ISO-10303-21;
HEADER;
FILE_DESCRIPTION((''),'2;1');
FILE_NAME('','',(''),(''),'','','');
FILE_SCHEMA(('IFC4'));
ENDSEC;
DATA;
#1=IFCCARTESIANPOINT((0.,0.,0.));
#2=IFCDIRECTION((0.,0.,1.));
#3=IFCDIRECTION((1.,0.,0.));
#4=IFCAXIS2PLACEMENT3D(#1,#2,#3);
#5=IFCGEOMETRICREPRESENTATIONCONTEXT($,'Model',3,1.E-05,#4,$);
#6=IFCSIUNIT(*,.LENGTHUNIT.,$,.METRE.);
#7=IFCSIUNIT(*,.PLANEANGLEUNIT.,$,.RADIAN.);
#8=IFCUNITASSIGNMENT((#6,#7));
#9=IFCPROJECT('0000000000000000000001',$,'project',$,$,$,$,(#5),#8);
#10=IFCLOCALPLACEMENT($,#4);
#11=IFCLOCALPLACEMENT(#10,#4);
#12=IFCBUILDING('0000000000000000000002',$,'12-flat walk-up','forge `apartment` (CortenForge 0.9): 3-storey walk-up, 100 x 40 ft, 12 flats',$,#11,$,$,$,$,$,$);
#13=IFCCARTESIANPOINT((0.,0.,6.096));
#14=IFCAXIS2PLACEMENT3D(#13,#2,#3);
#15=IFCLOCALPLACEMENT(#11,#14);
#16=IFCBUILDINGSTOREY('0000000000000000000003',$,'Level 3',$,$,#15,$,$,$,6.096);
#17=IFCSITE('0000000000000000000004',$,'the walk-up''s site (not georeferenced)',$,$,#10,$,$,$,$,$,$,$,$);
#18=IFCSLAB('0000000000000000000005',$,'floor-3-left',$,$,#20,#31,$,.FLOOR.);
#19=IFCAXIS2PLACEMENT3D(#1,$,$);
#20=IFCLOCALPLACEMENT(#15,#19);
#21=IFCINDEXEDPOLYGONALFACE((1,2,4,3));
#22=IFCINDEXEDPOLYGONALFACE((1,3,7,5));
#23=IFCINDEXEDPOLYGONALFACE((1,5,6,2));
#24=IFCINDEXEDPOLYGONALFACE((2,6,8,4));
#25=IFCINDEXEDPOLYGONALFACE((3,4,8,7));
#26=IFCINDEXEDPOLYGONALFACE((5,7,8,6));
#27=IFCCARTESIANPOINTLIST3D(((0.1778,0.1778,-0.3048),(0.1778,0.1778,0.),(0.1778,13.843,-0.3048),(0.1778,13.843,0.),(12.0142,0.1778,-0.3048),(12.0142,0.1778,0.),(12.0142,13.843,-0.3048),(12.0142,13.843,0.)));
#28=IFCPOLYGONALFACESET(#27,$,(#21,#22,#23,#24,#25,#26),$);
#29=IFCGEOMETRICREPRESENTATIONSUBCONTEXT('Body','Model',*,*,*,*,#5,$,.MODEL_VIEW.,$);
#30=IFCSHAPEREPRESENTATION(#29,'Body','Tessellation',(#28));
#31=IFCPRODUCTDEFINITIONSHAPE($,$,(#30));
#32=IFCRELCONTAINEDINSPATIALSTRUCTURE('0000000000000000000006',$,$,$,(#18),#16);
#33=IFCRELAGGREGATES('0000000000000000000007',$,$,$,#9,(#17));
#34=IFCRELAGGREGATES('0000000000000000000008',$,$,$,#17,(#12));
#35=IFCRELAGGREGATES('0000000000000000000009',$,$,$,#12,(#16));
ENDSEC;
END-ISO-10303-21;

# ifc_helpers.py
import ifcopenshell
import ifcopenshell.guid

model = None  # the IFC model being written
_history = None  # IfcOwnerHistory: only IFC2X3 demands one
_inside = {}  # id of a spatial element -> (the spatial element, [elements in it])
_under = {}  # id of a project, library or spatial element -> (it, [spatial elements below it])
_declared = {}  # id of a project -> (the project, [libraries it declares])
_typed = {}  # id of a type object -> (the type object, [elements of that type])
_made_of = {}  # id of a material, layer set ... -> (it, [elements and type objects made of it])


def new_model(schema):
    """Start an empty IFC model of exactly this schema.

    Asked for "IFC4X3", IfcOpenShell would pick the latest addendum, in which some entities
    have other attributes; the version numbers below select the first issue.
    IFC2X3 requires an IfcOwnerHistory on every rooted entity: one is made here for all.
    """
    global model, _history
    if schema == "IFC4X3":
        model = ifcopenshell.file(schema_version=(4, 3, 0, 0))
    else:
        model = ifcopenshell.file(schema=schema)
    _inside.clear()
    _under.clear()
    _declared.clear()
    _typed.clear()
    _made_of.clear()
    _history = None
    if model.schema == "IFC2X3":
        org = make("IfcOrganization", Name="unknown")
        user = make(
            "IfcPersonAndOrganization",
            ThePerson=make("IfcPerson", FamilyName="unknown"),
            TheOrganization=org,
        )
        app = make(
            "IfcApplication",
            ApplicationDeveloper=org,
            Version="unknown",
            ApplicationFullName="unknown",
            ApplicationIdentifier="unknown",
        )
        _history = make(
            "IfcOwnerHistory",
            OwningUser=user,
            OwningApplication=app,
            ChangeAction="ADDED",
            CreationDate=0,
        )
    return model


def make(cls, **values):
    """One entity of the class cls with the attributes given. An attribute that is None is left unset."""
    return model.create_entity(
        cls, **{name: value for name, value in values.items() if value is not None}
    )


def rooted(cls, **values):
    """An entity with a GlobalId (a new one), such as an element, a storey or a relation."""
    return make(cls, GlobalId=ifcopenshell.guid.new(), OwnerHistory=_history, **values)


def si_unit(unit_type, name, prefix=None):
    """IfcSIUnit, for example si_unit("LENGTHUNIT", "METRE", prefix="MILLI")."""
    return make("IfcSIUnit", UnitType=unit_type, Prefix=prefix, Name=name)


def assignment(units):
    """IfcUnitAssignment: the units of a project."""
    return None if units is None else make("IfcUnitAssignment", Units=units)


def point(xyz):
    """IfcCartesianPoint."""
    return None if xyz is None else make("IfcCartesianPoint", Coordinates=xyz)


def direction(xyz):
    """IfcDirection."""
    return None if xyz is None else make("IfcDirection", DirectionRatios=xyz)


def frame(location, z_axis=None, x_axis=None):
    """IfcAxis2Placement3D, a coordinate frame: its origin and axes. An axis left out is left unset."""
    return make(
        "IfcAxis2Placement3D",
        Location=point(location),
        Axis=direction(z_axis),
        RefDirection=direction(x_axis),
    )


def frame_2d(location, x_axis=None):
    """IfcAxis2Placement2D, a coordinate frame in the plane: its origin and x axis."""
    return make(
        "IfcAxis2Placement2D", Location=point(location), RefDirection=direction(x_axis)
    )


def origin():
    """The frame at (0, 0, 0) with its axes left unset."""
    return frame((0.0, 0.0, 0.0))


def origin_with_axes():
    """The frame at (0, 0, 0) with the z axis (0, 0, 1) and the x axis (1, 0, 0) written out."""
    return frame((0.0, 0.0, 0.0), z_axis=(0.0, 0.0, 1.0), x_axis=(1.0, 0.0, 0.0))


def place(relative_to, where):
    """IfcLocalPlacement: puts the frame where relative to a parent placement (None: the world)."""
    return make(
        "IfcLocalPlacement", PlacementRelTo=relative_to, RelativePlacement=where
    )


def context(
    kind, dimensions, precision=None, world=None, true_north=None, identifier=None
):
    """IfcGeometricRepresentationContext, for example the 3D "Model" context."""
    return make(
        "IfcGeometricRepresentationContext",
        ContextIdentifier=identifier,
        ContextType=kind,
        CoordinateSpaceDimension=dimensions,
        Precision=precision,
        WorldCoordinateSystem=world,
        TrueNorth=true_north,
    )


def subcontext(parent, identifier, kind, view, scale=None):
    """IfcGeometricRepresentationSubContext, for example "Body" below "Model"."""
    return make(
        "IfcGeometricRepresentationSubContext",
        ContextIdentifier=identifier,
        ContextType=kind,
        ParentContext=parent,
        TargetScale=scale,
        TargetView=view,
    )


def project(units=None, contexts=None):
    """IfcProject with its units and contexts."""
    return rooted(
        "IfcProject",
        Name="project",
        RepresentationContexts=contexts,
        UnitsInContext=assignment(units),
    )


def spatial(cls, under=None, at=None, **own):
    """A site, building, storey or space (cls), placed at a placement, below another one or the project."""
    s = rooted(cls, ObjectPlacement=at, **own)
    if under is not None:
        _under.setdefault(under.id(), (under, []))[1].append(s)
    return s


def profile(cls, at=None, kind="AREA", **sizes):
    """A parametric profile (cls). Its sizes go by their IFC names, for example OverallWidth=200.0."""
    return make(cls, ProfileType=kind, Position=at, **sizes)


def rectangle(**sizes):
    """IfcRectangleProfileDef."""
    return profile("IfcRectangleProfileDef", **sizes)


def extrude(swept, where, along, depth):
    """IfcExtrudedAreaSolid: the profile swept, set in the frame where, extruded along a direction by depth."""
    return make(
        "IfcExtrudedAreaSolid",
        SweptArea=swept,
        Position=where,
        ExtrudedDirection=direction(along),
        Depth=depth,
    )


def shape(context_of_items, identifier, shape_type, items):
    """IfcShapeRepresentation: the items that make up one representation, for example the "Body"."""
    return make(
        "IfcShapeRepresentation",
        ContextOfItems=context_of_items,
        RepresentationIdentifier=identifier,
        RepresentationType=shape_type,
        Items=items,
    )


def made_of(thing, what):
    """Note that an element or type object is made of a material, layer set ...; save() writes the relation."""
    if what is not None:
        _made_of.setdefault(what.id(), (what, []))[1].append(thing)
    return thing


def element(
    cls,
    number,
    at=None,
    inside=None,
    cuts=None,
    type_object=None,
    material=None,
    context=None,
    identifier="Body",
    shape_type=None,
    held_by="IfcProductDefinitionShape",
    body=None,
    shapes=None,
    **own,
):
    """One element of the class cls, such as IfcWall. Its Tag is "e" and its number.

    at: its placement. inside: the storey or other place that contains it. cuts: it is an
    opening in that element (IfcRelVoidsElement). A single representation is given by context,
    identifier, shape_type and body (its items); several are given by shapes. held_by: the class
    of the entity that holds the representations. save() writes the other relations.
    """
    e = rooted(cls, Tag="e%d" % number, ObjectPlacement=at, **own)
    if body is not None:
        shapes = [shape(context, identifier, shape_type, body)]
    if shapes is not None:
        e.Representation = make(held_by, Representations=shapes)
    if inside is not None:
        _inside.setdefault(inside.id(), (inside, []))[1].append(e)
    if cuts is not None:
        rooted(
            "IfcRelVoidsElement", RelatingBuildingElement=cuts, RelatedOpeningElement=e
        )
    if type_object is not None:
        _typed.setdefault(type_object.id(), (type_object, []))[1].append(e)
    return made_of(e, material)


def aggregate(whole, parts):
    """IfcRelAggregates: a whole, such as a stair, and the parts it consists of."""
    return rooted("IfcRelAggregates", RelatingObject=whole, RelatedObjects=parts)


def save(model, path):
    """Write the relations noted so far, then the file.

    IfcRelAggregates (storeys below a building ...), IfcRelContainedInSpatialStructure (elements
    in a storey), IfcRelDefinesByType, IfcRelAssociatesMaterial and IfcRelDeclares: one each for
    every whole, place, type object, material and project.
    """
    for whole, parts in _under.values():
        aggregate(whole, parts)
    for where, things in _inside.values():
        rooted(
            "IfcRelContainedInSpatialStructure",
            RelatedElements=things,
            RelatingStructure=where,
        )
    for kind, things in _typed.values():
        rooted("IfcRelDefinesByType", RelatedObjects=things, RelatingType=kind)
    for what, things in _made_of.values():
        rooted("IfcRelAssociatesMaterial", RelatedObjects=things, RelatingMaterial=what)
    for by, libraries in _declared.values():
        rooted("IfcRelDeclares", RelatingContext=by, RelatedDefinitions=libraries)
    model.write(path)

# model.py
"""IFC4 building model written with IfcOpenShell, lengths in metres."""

from ifc_helpers import new_model, si_unit, frame, frame_2d, origin, origin_with_axes, place, context, subcontext, project, spatial, rectangle, extrude, element, save


model = new_model("IFC4")

# Units and contexts
model_context = context("Model", 3, precision=1e-05, world=origin_with_axes())
body_context = subcontext(model_context, "Body", "Model", "MODEL_VIEW")
ifc_project = project(units=[si_unit("LENGTHUNIT", "METRE"), si_unit("PLANEANGLEUNIT", "RADIAN")], contexts=[model_context])

# Site, building, storey
site_placement = place(None, origin_with_axes())
site = spatial("IfcSite", under=ifc_project, at=site_placement, Name="the walk-up's site (not georeferenced)")
building_placement = place(site_placement, origin_with_axes())
building = spatial("IfcBuilding", under=site, at=building_placement, Name="12-flat walk-up", Description="forge `apartment` (CortenForge 0.9): 3-storey walk-up, 100 x 40 ft, 12 flats")
storey_placement = place(building_placement, frame((0.0, 0.0, 6.096), z_axis=(0.0, 0.0, 1.0), x_axis=(1.0, 0.0, 0.0)))
storey = spatial("IfcBuildingStorey", under=building, at=storey_placement, Name="Level 3", Elevation=6.096)

# Slab
slab_placement = place(storey_placement, frame((0.1778, 0.1778, -0.3048), z_axis=(0.0, 0.0, 1.0), x_axis=(1.0, 0.0, 0.0)))
element("IfcSlab", 1, at=slab_placement, inside=storey, Name="floor-3-left", PredefinedType="FLOOR", context=body_context, shape_type="SweptSolid", body=[
    extrude(rectangle(XDim=11.8364, YDim=13.6652, at=frame_2d((5.9182, 6.8326))), origin(), (0.0, 0.0, 1.0), 0.3048),
])

save(model, "model.ifc")
